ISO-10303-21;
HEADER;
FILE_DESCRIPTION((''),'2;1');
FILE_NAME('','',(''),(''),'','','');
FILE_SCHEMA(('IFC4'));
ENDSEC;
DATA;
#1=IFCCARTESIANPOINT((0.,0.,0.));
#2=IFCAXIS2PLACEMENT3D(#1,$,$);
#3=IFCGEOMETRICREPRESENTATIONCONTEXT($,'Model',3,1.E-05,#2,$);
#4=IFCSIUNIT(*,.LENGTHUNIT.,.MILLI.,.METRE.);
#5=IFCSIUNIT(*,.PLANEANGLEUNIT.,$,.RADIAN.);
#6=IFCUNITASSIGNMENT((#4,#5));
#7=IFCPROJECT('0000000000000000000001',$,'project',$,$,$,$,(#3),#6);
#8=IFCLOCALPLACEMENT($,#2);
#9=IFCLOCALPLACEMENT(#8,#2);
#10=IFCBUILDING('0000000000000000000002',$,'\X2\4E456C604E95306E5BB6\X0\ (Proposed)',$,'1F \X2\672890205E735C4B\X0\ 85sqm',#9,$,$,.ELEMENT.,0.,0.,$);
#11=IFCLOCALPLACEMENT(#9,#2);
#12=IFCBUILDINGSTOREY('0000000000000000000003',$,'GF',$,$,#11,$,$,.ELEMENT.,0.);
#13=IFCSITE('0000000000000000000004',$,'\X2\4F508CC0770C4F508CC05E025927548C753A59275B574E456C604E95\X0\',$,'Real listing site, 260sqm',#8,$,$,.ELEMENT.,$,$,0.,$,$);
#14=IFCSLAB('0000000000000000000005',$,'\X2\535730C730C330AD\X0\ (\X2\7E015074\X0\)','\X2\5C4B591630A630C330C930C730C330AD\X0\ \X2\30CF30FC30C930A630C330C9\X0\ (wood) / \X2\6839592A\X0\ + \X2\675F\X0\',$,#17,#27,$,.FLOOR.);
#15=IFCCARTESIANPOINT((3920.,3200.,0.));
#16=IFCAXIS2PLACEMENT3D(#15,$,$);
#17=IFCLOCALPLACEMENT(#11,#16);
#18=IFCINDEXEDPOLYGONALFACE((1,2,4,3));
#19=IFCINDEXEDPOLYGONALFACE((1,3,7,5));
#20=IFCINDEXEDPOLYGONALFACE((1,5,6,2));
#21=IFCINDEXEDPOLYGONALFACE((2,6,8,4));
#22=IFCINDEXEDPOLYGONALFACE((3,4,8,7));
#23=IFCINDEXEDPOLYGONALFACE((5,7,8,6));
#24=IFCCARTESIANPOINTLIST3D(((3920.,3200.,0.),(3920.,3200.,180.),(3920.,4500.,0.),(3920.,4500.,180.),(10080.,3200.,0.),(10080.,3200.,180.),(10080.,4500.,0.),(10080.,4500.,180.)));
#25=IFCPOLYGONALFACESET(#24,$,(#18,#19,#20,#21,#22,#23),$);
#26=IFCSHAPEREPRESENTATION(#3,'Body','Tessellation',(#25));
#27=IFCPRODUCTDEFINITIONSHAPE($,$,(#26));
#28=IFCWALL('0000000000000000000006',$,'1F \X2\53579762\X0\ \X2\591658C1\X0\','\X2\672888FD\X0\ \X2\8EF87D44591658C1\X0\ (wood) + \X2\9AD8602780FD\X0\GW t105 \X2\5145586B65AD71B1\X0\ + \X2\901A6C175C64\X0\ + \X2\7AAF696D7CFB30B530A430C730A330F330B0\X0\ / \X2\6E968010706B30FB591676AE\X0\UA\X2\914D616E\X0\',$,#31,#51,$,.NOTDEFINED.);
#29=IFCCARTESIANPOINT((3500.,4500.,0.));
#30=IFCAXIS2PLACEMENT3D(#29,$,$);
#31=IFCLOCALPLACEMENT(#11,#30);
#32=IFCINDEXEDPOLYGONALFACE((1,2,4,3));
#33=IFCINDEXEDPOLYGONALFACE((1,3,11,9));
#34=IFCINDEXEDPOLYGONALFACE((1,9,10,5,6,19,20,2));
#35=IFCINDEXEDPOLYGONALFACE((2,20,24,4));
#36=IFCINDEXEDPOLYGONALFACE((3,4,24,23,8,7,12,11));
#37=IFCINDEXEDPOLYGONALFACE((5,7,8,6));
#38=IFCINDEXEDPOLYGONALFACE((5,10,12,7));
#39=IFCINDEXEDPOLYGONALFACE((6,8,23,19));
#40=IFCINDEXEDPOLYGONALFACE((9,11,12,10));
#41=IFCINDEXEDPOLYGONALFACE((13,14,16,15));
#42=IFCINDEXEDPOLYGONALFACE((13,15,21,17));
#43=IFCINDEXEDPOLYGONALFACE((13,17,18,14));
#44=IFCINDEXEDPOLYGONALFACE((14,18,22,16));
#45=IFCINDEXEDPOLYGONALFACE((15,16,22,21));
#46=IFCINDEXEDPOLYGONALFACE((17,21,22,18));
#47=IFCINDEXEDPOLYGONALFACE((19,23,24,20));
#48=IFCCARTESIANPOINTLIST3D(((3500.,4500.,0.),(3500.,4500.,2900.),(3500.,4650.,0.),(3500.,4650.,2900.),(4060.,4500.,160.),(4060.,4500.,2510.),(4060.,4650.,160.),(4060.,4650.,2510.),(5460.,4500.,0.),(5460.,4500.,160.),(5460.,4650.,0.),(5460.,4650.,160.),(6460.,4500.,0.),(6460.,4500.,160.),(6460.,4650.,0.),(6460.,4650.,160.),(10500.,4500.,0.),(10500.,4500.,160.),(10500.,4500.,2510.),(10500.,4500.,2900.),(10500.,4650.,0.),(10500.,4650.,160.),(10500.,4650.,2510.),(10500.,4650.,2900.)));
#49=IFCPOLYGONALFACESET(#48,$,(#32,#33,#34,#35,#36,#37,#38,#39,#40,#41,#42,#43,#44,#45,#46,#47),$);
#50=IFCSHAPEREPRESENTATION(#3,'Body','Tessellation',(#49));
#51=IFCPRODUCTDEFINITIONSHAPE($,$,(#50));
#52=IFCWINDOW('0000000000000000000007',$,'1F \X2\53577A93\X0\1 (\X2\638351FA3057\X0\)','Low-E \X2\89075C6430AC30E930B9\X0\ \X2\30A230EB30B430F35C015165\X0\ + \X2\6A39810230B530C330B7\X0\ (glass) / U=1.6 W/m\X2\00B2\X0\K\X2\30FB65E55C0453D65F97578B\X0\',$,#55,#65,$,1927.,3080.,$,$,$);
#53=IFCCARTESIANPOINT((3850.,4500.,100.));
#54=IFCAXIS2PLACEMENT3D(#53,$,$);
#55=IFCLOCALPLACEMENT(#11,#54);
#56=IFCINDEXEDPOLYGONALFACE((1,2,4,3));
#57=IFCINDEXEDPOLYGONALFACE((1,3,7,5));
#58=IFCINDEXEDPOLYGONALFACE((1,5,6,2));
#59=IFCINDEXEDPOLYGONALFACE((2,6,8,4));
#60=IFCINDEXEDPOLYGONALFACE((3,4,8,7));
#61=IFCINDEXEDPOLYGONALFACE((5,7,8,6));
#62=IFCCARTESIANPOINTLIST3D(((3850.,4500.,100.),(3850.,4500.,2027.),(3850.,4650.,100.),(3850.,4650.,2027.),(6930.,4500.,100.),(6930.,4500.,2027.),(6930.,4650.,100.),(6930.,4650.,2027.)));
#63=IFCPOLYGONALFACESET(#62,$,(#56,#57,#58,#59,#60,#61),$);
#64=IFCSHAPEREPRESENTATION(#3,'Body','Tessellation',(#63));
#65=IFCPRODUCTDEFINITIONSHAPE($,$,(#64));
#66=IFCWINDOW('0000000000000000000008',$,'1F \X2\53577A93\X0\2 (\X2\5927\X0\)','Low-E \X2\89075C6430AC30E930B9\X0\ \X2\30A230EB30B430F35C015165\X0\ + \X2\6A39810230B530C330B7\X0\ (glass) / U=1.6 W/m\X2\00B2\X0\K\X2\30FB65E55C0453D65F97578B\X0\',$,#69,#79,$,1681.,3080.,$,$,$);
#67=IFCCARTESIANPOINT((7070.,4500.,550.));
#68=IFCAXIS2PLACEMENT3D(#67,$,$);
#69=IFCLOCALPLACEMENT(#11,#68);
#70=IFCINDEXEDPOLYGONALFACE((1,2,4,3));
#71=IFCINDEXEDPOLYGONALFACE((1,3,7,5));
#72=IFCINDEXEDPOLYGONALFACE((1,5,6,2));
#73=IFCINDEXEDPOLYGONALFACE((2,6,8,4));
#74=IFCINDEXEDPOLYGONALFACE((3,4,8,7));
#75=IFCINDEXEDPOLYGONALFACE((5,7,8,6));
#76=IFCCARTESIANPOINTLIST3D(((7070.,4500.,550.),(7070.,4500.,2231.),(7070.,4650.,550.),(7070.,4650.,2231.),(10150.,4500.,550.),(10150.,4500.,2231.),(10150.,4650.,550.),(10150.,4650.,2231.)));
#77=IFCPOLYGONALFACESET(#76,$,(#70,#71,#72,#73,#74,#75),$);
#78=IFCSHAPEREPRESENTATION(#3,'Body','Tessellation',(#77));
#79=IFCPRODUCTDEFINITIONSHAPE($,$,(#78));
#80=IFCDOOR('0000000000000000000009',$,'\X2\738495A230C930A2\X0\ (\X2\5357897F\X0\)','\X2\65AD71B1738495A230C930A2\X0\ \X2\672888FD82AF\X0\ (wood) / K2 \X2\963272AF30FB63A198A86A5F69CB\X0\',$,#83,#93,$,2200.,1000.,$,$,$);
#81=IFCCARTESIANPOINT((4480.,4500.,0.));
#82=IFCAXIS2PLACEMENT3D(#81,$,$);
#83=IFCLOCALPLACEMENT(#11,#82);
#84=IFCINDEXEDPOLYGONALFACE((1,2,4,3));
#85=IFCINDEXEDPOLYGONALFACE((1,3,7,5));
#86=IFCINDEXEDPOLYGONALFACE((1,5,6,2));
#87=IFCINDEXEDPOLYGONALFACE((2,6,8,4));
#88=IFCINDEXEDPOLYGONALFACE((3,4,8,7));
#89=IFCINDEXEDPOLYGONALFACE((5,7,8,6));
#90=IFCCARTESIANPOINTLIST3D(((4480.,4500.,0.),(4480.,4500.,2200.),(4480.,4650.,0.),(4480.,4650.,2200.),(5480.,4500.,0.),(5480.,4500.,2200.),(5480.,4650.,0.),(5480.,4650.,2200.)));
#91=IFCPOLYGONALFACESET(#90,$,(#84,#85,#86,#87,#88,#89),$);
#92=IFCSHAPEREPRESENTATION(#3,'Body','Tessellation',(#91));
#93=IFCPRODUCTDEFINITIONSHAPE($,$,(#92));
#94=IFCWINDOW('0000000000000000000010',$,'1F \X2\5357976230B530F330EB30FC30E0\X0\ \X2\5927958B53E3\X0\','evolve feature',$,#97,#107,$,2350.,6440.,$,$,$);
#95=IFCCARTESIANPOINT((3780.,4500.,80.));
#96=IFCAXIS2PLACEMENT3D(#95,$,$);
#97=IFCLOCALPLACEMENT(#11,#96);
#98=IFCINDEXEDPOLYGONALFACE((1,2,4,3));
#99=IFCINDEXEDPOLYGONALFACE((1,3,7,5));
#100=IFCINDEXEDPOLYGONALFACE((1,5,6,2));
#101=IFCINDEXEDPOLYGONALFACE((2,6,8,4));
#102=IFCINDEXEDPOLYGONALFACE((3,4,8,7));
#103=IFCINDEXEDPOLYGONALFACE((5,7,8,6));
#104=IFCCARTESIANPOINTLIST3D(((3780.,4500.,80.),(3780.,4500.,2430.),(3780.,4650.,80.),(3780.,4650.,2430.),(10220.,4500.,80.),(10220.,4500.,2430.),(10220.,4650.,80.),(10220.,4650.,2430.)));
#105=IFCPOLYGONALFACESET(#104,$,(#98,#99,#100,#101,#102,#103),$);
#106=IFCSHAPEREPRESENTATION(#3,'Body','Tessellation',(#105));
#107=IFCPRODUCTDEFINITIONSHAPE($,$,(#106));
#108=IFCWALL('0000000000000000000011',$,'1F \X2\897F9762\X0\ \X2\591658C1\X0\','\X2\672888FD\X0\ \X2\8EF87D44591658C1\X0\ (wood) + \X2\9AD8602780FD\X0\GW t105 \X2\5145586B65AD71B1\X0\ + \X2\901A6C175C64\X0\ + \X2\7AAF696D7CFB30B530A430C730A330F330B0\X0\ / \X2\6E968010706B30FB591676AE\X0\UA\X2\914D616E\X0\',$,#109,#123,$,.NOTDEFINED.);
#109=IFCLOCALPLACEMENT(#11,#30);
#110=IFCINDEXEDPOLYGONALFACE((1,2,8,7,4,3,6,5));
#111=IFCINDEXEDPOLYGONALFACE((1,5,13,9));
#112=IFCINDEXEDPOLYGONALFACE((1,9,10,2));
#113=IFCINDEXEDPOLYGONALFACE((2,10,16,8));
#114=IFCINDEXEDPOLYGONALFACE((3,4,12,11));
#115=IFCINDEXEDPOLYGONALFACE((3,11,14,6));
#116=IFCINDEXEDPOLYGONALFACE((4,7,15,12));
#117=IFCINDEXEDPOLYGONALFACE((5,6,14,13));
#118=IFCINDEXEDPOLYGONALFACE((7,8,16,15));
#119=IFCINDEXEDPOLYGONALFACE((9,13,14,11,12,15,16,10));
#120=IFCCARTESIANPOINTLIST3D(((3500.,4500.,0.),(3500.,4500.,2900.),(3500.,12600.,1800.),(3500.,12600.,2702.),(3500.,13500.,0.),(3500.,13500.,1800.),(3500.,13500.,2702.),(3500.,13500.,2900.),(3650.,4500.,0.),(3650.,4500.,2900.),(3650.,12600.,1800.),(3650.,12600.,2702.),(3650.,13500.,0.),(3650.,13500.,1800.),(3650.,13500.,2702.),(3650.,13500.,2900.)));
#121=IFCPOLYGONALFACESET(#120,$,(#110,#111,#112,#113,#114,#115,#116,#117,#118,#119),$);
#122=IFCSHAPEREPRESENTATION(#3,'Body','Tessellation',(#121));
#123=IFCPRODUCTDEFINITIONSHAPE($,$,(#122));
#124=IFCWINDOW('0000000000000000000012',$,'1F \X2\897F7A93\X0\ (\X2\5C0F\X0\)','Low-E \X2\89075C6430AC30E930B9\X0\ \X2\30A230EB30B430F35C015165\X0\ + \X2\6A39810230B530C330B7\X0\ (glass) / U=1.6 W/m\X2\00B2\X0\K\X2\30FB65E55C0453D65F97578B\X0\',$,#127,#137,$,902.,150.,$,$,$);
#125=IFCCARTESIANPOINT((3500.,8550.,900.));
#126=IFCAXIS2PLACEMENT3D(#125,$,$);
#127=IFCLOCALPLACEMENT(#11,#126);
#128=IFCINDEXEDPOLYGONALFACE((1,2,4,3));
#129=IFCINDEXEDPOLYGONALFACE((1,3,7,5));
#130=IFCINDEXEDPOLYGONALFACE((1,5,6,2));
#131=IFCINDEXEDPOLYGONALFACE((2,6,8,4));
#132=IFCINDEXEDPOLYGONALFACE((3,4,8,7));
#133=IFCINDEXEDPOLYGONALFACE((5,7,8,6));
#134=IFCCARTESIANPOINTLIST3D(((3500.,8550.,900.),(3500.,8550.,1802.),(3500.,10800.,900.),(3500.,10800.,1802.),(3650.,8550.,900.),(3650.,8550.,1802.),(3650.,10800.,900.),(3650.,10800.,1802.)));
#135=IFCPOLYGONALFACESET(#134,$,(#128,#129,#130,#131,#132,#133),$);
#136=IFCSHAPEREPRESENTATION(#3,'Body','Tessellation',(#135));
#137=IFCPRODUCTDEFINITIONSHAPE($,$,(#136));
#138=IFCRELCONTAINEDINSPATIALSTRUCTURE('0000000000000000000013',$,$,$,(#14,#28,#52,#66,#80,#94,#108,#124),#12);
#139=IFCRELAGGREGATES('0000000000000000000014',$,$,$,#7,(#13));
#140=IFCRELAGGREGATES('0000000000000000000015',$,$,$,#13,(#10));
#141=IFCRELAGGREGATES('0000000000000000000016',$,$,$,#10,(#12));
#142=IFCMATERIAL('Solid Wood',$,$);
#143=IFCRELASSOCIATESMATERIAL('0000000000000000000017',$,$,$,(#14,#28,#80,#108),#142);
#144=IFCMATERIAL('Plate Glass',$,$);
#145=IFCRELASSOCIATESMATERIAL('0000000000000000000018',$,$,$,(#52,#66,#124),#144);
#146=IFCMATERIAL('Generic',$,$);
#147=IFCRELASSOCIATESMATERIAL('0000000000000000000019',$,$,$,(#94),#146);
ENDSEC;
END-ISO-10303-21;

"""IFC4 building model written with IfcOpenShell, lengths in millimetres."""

from ifc_helpers import new_model, si_unit, frame, frame_2d, origin, place, context, project, spatial, rectangle, extrude, material, element, fill, save


model = new_model("IFC4")

# Units and contexts
model_context = context("Model", 3, precision=1e-05, world=origin())
ifc_project = project(units=[si_unit("LENGTHUNIT", "METRE", prefix="MILLI"), si_unit("PLANEANGLEUNIT", "RADIAN")], contexts=[model_context])

# Site, building, storey
site_placement = place(None, origin())
site = spatial("IfcSite", under=ifc_project, at=site_placement, Name="佐賀県佐賀市大和町大字久池井", ObjectType="Real listing site, 260sqm", CompositionType="ELEMENT", RefElevation=0.0)
building_placement = place(site_placement, origin())
building = spatial("IfcBuilding", under=site, at=building_placement, Name="久池井の家 (Proposed)", ObjectType="1F 木造平屋 85sqm", CompositionType="ELEMENT", ElevationOfRefHeight=0.0, ElevationOfTerrain=0.0)
storey_placement = place(building_placement, origin())
storey = spatial("IfcBuildingStorey", under=building, at=storey_placement, Name="GF", CompositionType="ELEMENT", Elevation=0.0)

# Slab
ifc_material_1 = material(Name="Solid Wood")
slab_1_placement = place(storey_placement, frame((3920.0, 3200.0, 0.0)))
element("IfcSlab", 1, at=slab_1_placement, inside=storey, material=ifc_material_1, Name="南デッキ (縁側)", Description="屋外ウッドデッキ ハードウッド (wood) / 根太 + 束", PredefinedType="FLOOR", context=model_context, shape_type="SweptSolid", body=[
    extrude(rectangle(XDim=6160.0, YDim=1300.0, at=frame_2d((3080.0, 650.0))), frame((3920.0, 3200.0, 0.0)), (0.0, 0.0, 1.0), 180.0),
])
ifc_material_2 = material(Name="Generic")

# Wall, openings, windows, door
wall_1_placement = place(storey_placement, frame((3500.0, 4500.0, 0.0)))
wall_1 = element("IfcWall", 2, at=wall_1_placement, inside=storey, material=ifc_material_1, Name="1F 南面 外壁", Description="木製 軸組外壁 (wood) + 高性能GW t105 充填断熱 + 通気層 + 窯業系サイディング / 準耐火・外皮UA配慮", PredefinedType="NOTDEFINED", context=model_context, shape_type="SweptSolid", body=[
    extrude(rectangle(XDim=7000.0, YDim=150.0, at=frame_2d((3500.0, 75.0))), frame((3500.0, 4500.0, 0.0)), (0.0, 0.0, 1.0), 2900.0),
])
opening_1_placement = place(storey_placement, frame((3850.0, 4500.0, 100.0)))
opening_1 = element("IfcOpeningElement", 3, at=opening_1_placement, cuts=wall_1, PredefinedType="NOTDEFINED", context=model_context, shape_type="SweptSolid", body=[
    extrude(rectangle(XDim=3080.0, YDim=150.0, at=frame_2d((1540.0, 75.0))), frame((3850.0, 4500.0, 100.0)), (0.0, 0.0, 1.0), 1927.0),
])
opening_2_placement = place(storey_placement, frame((7070.0, 4500.0, 550.0)))
opening_2 = element("IfcOpeningElement", 4, at=opening_2_placement, cuts=wall_1, PredefinedType="NOTDEFINED", context=model_context, shape_type="SweptSolid", body=[
    extrude(rectangle(XDim=3080.0, YDim=150.0, at=frame_2d((1540.0, 75.0))), frame((7070.0, 4500.0, 550.0)), (0.0, 0.0, 1.0), 1681.0),
])
opening_3_placement = place(storey_placement, frame((4480.0, 4500.0, 0.0)))
opening_3 = element("IfcOpeningElement", 5, at=opening_3_placement, cuts=wall_1, PredefinedType="NOTDEFINED", context=model_context, shape_type="SweptSolid", body=[
    extrude(rectangle(XDim=1000.0, YDim=150.0, at=frame_2d((500.0, 75.0))), frame((4480.0, 4500.0, 0.0)), (0.0, 0.0, 1.0), 2200.0),
])
opening_4_placement = place(storey_placement, frame((3780.0, 4500.0, 80.0)))
opening_4 = element("IfcOpeningElement", 6, at=opening_4_placement, cuts=wall_1, PredefinedType="NOTDEFINED", context=model_context, shape_type="SweptSolid", body=[
    extrude(rectangle(XDim=6440.0, YDim=150.0, at=frame_2d((3220.0, 75.0))), frame((3780.0, 4500.0, 80.0)), (0.0, 0.0, 1.0), 2350.0),
])
ifc_material_3 = material(Name="Plate Glass")
window_1_placement = place(storey_placement, frame((3850.0, 4500.0, 100.0)))
window_1 = element("IfcWindow", 7, at=window_1_placement, inside=storey, material=ifc_material_3, Name="1F 南窓1 (掃出し)", Description="Low-E 複層ガラス アルゴン封入 + 樹脂サッシ (glass) / U=1.6 W/m²K・日射取得型", OverallHeight=1927.0, OverallWidth=3080.0, context=model_context, shape_type="SweptSolid", body=[
    extrude(rectangle(XDim=3080.0, YDim=150.0, at=frame_2d((1540.0, 75.0))), frame((3850.0, 4500.0, 100.0)), (0.0, 0.0, 1.0), 1927.0),
])
fill(opening_1, window_1)
window_2_placement = place(storey_placement, frame((7070.0, 4500.0, 550.0)))
window_2 = element("IfcWindow", 8, at=window_2_placement, inside=storey, material=ifc_material_3, Name="1F 南窓2 (大)", Description="Low-E 複層ガラス アルゴン封入 + 樹脂サッシ (glass) / U=1.6 W/m²K・日射取得型", OverallHeight=1681.0, OverallWidth=3080.0, context=model_context, shape_type="SweptSolid", body=[
    extrude(rectangle(XDim=3080.0, YDim=150.0, at=frame_2d((1540.0, 75.0))), frame((7070.0, 4500.0, 550.0)), (0.0, 0.0, 1.0), 1681.0),
])
fill(opening_2, window_2)
door_placement = place(storey_placement, frame((4480.0, 4500.0, 0.0)))
door = element("IfcDoor", 9, at=door_placement, inside=storey, material=ifc_material_1, Name="玄関ドア (南西)", Description="断熱玄関ドア 木製芯 (wood) / K2 防犯・採風機構", OverallHeight=2200.0, OverallWidth=1000.0, context=model_context, shape_type="SweptSolid", body=[
    extrude(rectangle(XDim=1000.0, YDim=150.0, at=frame_2d((500.0, 75.0))), frame((4480.0, 4500.0, 0.0)), (0.0, 0.0, 1.0), 2200.0),
])
fill(opening_3, door)
window_3_placement = place(storey_placement, frame((3780.0, 4500.0, 80.0)))
window_3 = element("IfcWindow", 10, at=window_3_placement, inside=storey, material=ifc_material_2, Name="1F 南面サンルーム 大開口", Description="evolve feature", OverallHeight=2350.0, OverallWidth=6440.0, context=model_context, shape_type="SweptSolid", body=[
    extrude(rectangle(XDim=6440.0, YDim=150.0, at=frame_2d((3220.0, 75.0))), frame((3780.0, 4500.0, 80.0)), (0.0, 0.0, 1.0), 2350.0),
])
fill(opening_4, window_3)

# Wall, opening, window
wall_2_placement = place(storey_placement, frame((3500.0, 4500.0, 0.0)))
wall_2 = element("IfcWall", 11, at=wall_2_placement, inside=storey, material=ifc_material_1, Name="1F 西面 外壁", Description="木製 軸組外壁 (wood) + 高性能GW t105 充填断熱 + 通気層 + 窯業系サイディング / 準耐火・外皮UA配慮", PredefinedType="NOTDEFINED", context=model_context, shape_type="SweptSolid", body=[
    extrude(rectangle(XDim=150.0, YDim=9000.0, at=frame_2d((75.0, 4500.0))), frame((3500.0, 4500.0, 0.0)), (0.0, 0.0, 1.0), 2900.0),
])
opening_5_placement = place(storey_placement, frame((3500.0, 8550.0, 900.0)))
opening_5 = element("IfcOpeningElement", 12, at=opening_5_placement, cuts=wall_2, PredefinedType="NOTDEFINED", context=model_context, shape_type="SweptSolid", body=[
    extrude(rectangle(XDim=150.0, YDim=2250.0, at=frame_2d((75.0, 1125.0))), frame((3500.0, 8550.0, 900.0)), (0.0, 0.0, 1.0), 902.0),
])
window_4_placement = place(storey_placement, frame((3500.0, 8550.0, 900.0)))
window_4 = element("IfcWindow", 13, at=window_4_placement, inside=storey, material=ifc_material_3, Name="1F 西窓 (小)", Description="Low-E 複層ガラス アルゴン封入 + 樹脂サッシ (glass) / U=1.6 W/m²K・日射取得型", OverallHeight=902.0, OverallWidth=150.0, context=model_context, shape_type="SweptSolid", body=[
    extrude(rectangle(XDim=150.0, YDim=2250.0, at=frame_2d((75.0, 1125.0))), frame((3500.0, 8550.0, 900.0)), (0.0, 0.0, 1.0), 902.0),
])
fill(opening_5, window_4)

save(model, "model.ifc")
